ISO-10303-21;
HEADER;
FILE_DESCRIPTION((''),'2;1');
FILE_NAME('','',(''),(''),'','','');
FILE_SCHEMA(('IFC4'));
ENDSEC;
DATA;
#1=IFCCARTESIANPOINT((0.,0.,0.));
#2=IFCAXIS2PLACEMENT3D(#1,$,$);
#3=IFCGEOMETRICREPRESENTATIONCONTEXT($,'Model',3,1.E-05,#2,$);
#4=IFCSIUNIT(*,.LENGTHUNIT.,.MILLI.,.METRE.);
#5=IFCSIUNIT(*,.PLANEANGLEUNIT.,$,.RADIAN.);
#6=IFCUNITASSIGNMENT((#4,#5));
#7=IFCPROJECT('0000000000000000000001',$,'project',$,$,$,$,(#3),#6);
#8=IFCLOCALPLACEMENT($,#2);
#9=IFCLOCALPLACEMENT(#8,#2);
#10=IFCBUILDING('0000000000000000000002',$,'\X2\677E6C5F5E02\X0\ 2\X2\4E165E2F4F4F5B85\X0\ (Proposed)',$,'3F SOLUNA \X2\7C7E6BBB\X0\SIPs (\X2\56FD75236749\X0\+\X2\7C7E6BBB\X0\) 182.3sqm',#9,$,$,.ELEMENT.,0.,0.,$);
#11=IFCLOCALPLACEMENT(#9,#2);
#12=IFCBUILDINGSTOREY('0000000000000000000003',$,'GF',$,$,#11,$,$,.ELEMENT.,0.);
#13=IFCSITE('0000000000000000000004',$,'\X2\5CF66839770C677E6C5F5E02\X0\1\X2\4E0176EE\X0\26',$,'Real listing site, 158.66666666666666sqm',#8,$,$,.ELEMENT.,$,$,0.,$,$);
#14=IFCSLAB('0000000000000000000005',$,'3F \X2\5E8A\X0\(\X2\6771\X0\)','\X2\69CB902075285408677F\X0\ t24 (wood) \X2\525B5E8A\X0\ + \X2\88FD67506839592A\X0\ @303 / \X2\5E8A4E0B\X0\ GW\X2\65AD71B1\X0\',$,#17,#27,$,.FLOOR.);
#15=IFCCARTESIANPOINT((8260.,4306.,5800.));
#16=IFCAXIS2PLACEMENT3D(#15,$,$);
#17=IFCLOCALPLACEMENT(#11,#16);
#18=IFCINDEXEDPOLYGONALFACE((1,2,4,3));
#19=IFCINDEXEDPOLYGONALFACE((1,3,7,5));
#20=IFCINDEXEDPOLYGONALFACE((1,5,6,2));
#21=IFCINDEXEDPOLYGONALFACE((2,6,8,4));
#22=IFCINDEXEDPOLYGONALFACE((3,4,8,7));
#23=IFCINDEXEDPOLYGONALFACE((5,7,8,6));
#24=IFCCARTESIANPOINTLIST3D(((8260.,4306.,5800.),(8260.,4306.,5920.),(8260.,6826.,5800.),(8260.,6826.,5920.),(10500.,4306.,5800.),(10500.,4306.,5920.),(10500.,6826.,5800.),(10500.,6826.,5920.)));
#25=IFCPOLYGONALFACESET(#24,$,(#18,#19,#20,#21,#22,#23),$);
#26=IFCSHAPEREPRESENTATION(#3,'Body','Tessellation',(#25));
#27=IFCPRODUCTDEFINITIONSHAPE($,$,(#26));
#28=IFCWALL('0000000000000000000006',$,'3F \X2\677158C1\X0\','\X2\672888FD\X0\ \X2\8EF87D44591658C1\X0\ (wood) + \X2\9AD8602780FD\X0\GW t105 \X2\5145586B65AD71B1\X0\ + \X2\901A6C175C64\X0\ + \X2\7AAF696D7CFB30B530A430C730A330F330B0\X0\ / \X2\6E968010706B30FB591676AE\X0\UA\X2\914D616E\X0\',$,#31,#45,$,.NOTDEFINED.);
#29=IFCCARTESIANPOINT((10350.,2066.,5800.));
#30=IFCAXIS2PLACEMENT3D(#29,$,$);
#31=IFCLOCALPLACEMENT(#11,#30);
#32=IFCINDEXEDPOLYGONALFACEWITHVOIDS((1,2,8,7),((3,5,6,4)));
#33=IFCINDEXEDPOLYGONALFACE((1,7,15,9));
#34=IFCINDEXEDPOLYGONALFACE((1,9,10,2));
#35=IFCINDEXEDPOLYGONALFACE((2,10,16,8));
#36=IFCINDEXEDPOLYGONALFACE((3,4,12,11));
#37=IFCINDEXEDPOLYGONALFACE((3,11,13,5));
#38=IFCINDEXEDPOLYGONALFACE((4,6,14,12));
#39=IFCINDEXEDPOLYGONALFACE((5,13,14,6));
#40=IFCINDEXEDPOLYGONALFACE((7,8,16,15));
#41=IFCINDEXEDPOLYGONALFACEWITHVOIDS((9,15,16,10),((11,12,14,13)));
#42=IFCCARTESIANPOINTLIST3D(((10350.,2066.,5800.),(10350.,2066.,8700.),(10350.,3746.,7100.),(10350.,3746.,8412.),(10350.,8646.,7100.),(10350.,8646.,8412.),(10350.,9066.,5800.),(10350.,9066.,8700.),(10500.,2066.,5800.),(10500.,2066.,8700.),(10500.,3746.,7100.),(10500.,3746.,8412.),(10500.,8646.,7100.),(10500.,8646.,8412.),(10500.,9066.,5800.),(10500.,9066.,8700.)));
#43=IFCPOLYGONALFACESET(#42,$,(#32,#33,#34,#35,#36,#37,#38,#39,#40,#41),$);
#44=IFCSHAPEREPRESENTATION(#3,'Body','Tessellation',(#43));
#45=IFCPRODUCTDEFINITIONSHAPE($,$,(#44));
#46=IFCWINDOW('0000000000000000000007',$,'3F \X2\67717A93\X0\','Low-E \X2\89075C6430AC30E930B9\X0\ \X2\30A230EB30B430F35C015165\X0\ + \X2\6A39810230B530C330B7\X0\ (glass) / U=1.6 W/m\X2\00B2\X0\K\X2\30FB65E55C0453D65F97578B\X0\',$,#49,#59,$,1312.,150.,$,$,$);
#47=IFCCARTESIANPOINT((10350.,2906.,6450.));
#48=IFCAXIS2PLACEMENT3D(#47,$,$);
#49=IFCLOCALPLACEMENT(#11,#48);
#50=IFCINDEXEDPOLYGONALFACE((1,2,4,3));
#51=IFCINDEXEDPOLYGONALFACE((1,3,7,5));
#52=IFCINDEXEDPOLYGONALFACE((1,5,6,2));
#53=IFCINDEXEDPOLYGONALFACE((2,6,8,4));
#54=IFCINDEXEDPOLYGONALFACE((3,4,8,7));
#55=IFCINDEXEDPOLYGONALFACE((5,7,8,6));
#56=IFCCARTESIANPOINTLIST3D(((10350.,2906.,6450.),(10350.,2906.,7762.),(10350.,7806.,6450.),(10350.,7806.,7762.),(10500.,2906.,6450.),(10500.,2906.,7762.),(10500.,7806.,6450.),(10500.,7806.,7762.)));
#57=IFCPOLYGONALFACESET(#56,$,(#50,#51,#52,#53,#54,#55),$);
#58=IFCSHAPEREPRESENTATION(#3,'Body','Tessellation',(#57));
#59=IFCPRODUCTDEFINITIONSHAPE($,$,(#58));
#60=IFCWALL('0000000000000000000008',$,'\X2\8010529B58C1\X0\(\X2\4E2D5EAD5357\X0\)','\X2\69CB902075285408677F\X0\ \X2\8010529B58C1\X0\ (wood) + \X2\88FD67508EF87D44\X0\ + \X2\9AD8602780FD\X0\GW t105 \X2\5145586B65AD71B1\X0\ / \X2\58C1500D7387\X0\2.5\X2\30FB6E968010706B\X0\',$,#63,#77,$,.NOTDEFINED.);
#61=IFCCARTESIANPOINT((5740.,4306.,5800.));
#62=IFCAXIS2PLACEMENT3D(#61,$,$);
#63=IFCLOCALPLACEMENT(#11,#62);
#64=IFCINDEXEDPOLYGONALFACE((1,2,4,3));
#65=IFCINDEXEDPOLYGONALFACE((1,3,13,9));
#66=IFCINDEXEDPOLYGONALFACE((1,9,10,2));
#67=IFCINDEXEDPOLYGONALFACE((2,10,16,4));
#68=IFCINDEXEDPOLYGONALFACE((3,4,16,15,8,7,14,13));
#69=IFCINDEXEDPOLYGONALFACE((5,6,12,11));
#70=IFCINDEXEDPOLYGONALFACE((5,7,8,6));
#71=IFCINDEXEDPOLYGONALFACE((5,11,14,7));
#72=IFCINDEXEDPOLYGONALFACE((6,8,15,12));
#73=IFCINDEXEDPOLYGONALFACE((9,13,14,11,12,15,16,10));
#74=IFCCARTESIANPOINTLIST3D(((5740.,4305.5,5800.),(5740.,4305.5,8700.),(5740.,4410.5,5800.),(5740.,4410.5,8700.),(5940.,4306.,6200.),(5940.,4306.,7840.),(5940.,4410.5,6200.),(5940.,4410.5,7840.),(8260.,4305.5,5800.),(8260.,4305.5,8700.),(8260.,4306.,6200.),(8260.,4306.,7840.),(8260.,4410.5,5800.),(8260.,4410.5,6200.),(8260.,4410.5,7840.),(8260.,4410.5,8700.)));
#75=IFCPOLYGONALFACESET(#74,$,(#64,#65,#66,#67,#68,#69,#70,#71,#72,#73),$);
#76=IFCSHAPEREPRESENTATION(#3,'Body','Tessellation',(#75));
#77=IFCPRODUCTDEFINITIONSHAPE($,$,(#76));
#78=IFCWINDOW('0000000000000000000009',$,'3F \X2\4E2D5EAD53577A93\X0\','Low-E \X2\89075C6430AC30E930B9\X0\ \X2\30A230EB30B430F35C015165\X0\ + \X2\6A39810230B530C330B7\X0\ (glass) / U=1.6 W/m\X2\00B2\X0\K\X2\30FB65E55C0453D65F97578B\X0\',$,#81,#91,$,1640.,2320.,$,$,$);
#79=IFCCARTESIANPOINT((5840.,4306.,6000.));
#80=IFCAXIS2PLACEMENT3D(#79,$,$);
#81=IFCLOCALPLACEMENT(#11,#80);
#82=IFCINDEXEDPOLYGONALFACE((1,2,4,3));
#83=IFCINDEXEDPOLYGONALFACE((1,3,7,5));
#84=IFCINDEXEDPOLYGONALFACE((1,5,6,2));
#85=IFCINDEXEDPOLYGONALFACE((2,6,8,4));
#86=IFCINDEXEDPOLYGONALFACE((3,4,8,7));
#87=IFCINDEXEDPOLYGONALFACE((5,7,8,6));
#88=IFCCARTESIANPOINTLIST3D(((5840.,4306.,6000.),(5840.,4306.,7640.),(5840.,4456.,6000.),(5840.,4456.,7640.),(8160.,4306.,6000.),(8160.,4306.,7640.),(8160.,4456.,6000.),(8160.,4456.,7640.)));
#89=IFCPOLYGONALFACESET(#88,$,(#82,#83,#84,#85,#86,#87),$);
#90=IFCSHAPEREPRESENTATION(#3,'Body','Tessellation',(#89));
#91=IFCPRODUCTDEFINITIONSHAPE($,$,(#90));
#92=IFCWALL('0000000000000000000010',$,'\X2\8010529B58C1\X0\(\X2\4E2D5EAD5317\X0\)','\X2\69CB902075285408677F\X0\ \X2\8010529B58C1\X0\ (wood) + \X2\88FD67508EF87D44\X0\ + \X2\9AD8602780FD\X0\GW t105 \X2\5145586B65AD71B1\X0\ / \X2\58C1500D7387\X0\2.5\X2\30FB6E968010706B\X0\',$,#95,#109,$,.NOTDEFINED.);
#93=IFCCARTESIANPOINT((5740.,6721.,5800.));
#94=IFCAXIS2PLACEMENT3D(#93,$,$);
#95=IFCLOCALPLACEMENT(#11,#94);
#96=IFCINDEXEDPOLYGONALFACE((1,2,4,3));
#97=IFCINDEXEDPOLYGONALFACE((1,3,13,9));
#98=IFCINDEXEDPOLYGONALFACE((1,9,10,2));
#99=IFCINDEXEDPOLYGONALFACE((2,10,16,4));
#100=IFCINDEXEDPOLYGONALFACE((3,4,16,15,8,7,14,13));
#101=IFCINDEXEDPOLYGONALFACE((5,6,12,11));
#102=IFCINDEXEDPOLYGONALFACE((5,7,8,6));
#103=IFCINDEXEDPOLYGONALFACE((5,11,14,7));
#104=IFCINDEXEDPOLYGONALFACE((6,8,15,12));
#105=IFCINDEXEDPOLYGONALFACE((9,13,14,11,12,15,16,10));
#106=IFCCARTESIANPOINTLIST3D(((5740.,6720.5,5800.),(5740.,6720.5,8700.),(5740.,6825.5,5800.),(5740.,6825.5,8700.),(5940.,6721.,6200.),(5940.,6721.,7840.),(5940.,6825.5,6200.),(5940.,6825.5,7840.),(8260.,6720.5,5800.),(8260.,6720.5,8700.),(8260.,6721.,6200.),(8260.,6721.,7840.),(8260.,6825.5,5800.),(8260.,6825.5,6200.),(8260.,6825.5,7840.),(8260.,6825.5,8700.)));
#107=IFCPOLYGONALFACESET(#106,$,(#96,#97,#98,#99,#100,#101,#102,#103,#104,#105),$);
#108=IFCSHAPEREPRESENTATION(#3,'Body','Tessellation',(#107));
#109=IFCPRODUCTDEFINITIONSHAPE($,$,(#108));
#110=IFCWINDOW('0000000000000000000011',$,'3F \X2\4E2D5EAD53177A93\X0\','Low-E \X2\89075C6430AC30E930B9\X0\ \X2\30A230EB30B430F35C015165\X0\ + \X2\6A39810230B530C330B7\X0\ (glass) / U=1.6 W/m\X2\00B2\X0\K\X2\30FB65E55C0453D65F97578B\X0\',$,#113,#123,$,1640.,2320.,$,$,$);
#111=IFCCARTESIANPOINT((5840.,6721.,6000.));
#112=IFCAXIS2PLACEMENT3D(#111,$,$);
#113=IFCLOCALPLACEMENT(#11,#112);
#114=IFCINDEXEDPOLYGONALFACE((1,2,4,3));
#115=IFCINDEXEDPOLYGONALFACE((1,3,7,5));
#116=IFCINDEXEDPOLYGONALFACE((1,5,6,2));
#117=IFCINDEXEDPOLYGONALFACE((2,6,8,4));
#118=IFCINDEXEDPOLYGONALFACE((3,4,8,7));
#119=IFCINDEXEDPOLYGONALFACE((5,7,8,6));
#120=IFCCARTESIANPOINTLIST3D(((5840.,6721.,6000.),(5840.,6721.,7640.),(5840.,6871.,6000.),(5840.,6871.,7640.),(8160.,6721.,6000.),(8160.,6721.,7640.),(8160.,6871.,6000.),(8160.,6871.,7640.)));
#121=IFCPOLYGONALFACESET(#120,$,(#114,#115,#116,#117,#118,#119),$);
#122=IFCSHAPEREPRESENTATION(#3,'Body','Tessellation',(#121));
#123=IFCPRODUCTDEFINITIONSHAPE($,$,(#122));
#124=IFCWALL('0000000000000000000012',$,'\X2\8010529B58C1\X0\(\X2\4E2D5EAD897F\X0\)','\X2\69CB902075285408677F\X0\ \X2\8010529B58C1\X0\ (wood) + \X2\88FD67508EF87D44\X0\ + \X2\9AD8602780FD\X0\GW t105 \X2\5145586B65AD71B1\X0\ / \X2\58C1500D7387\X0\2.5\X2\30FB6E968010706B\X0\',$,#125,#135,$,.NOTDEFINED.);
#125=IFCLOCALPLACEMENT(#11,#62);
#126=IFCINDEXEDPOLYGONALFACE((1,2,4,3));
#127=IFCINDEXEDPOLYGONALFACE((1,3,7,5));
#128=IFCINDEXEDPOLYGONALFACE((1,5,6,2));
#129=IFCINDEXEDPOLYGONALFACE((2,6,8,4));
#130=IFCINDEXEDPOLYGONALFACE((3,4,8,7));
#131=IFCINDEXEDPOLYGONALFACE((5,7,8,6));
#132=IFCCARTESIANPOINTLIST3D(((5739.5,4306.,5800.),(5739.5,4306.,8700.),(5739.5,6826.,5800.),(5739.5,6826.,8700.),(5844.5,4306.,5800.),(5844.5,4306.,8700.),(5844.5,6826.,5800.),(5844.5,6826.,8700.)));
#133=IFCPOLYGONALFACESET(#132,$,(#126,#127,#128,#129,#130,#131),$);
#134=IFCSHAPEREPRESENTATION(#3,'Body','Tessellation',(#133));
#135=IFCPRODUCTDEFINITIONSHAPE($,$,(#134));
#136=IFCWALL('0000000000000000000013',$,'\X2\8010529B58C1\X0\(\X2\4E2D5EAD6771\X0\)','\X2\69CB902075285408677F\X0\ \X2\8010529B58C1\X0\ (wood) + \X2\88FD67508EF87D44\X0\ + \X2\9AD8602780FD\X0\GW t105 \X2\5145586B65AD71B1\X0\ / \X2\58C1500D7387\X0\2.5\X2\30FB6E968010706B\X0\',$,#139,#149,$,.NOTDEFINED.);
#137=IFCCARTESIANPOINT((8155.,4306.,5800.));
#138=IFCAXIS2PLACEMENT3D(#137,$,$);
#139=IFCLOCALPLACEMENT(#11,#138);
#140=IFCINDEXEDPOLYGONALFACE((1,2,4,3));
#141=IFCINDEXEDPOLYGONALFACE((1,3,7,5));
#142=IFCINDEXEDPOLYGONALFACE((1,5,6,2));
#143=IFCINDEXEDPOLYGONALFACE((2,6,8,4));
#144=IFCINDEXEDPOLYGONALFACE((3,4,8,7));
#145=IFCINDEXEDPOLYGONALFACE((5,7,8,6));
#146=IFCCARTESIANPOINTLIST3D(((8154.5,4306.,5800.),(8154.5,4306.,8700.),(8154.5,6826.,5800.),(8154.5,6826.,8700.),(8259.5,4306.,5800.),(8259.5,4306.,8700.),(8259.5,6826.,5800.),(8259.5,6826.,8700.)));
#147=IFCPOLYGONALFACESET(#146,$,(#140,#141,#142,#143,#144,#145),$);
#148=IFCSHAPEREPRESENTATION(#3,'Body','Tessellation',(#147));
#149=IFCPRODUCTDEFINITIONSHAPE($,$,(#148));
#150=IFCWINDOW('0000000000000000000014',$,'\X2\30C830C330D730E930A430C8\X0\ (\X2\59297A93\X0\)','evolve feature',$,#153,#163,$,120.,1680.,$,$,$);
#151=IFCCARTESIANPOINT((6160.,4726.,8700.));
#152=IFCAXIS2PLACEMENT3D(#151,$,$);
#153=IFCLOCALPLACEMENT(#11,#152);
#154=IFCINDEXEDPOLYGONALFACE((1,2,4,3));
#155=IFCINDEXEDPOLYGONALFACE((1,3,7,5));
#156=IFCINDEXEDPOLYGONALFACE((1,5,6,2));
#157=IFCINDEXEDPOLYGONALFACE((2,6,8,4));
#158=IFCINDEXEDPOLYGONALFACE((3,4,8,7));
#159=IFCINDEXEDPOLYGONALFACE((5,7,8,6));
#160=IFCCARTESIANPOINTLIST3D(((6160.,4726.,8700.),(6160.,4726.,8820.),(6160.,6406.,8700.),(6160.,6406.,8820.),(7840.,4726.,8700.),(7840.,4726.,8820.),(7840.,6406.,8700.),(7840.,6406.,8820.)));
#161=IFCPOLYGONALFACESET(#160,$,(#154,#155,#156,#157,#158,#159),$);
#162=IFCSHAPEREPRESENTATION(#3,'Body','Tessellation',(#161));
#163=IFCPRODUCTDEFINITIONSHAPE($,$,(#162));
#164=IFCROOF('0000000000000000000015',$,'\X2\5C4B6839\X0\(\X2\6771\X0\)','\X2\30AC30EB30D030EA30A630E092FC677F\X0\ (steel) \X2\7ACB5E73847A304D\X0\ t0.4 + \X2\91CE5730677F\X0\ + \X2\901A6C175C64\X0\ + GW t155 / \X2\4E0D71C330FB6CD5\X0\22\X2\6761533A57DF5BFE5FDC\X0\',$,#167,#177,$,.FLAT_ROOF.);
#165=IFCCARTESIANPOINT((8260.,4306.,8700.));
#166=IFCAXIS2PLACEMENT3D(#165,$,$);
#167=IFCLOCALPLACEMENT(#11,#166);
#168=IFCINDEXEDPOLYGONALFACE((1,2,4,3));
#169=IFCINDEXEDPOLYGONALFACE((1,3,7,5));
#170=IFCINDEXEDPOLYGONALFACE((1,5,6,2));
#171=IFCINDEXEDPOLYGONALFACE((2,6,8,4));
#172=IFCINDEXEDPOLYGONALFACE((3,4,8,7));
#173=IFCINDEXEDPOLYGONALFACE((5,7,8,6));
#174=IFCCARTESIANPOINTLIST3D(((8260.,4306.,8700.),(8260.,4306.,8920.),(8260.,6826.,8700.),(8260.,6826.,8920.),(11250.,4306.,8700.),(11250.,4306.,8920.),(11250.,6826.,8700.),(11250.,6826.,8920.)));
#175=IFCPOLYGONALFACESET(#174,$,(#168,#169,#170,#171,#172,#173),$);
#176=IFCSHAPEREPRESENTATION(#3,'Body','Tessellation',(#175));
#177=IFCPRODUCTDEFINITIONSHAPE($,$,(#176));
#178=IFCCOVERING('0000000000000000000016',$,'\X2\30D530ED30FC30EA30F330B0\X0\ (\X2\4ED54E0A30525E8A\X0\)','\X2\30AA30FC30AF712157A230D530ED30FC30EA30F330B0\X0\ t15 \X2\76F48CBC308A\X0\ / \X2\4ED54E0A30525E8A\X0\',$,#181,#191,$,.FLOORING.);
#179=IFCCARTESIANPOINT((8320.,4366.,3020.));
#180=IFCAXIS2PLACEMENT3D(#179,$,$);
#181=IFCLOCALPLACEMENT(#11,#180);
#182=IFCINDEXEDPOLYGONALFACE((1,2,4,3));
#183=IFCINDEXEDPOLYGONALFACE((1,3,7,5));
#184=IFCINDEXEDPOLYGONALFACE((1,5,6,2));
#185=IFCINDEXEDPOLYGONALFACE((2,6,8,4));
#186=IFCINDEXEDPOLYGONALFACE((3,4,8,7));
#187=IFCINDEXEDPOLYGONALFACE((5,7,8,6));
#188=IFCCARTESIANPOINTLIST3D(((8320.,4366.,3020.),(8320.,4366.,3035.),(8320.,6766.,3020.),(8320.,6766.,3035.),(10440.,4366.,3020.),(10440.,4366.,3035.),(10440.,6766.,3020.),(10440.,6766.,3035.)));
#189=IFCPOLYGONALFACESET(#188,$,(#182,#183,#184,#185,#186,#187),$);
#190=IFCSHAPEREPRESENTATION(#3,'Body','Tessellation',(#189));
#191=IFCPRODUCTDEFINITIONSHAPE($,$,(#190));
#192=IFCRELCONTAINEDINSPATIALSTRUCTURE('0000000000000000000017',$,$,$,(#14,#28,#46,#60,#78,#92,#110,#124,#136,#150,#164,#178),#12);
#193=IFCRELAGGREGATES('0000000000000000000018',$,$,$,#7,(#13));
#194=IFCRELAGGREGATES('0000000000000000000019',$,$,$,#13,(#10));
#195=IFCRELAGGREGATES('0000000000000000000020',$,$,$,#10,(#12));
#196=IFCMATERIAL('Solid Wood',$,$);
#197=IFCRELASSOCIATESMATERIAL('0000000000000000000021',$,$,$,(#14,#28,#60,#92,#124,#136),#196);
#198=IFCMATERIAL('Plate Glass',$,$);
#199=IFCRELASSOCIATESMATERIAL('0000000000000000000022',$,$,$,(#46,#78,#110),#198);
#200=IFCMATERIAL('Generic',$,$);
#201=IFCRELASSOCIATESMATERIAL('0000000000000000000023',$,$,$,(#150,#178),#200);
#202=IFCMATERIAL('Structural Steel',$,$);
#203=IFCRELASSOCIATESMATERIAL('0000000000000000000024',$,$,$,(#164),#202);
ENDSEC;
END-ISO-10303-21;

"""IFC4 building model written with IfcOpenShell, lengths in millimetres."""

from ifc_helpers import new_model, si_unit, frame, frame_2d, origin, place, context, project, spatial, rectangle, extrude, material, element, fill, save


model = new_model("IFC4")

# Units and contexts
model_context = context("Model", 3, precision=1e-05, world=origin())
ifc_project = project(units=[si_unit("LENGTHUNIT", "METRE", prefix="MILLI"), si_unit("PLANEANGLEUNIT", "RADIAN")], contexts=[model_context])

# Site, building, storey
site_placement = place(None, origin())
site = spatial("IfcSite", under=ifc_project, at=site_placement, Name="島根県松江市1丁目26", ObjectType="Real listing site, 158.66666666666666sqm", CompositionType="ELEMENT", RefElevation=0.0)
building_placement = place(site_placement, origin())
building = spatial("IfcBuilding", under=site, at=building_placement, Name="松江市 2世帯住宅 (Proposed)", ObjectType="3F SOLUNA 籾殻SIPs (国産杉+籾殻) 182.3sqm", CompositionType="ELEMENT", ElevationOfRefHeight=0.0, ElevationOfTerrain=0.0)
storey_placement = place(building_placement, origin())
storey = spatial("IfcBuildingStorey", under=building, at=storey_placement, Name="GF", CompositionType="ELEMENT", Elevation=0.0)

# Slab
ifc_material_1 = material(Name="Solid Wood")
slab_placement = place(storey_placement, frame((8260.0, 4306.0, 5800.0)))
element("IfcSlab", 1, at=slab_placement, inside=storey, material=ifc_material_1, Name="3F 床(東)", Description="構造用合板 t24 (wood) 剛床 + 製材根太 @303 / 床下 GW断熱", PredefinedType="FLOOR", context=model_context, shape_type="SweptSolid", body=[
    extrude(rectangle(XDim=2240.0, YDim=2520.0, at=frame_2d((1120.0, 1260.0))), frame((8260.0, 4306.0, 5800.0)), (0.0, 0.0, 1.0), 120.0),
])

# Walls, openings, windows
wall_1_placement = place(storey_placement, frame((10350.0, 2066.0, 5800.0)))
wall_1 = element("IfcWall", 2, at=wall_1_placement, inside=storey, material=ifc_material_1, Name="3F 東壁", Description="木製 軸組外壁 (wood) + 高性能GW t105 充填断熱 + 通気層 + 窯業系サイディング / 準耐火・外皮UA配慮", PredefinedType="NOTDEFINED", context=model_context, shape_type="SweptSolid", body=[
    extrude(rectangle(XDim=150.0, YDim=7000.0, at=frame_2d((75.0, 3500.0))), frame((10350.0, 2066.0, 5800.0)), (0.0, 0.0, 1.0), 2900.0),
])
opening_1_placement = place(storey_placement, frame((10350.0, 2906.0, 6450.0)))
opening_1 = element("IfcOpeningElement", 3, at=opening_1_placement, cuts=wall_1, PredefinedType="NOTDEFINED", context=model_context, shape_type="SweptSolid", body=[
    extrude(rectangle(XDim=150.0, YDim=4900.0, at=frame_2d((75.0, 2450.0))), frame((10350.0, 2906.0, 6450.0)), (0.0, 0.0, 1.0), 1312.0),
])
ifc_material_2 = material(Name="Plate Glass")
window_1_placement = place(storey_placement, frame((10350.0, 2906.0, 6450.0)))
window_1 = element("IfcWindow", 4, at=window_1_placement, inside=storey, material=ifc_material_2, Name="3F 東窓", Description="Low-E 複層ガラス アルゴン封入 + 樹脂サッシ (glass) / U=1.6 W/m²K・日射取得型", OverallHeight=1312.0, OverallWidth=150.0, context=model_context, shape_type="SweptSolid", body=[
    extrude(rectangle(XDim=150.0, YDim=4900.0, at=frame_2d((75.0, 2450.0))), frame((10350.0, 2906.0, 6450.0)), (0.0, 0.0, 1.0), 1312.0),
])
fill(opening_1, window_1)
wall_2_placement = place(storey_placement, frame((5740.0, 4306.0, 5800.0)))
wall_2 = element("IfcWall", 5, at=wall_2_placement, inside=storey, material=ifc_material_1, Name="耐力壁(中庭南)", Description="構造用合板 耐力壁 (wood) + 製材軸組 + 高性能GW t105 充填断熱 / 壁倍率2.5・準耐火", PredefinedType="NOTDEFINED", context=model_context, shape_type="SweptSolid", body=[
    extrude(rectangle(XDim=2520.0, YDim=105.0, at=frame_2d((1260.0, 52.0))), frame((5740.0, 4306.0, 5800.0)), (0.0, 0.0, 1.0), 2900.0),
])
opening_2_placement = place(storey_placement, frame((5840.0, 4306.0, 6000.0)))
opening_2 = element("IfcOpeningElement", 6, at=opening_2_placement, cuts=wall_2, PredefinedType="NOTDEFINED", context=model_context, shape_type="SweptSolid", body=[
    extrude(rectangle(XDim=2320.0, YDim=150.0, at=frame_2d((1160.0, 75.0))), frame((5840.0, 4306.0, 6000.0)), (0.0, 0.0, 1.0), 1640.0),
])
window_2_placement = place(storey_placement, frame((5840.0, 4306.0, 6000.0)))
window_2 = element("IfcWindow", 7, at=window_2_placement, inside=storey, material=ifc_material_2, Name="3F 中庭南窓", Description="Low-E 複層ガラス アルゴン封入 + 樹脂サッシ (glass) / U=1.6 W/m²K・日射取得型", OverallHeight=1640.0, OverallWidth=2320.0, context=model_context, shape_type="SweptSolid", body=[
    extrude(rectangle(XDim=2320.0, YDim=150.0, at=frame_2d((1160.0, 75.0))), frame((5840.0, 4306.0, 6000.0)), (0.0, 0.0, 1.0), 1640.0),
])
fill(opening_2, window_2)
wall_3_placement = place(storey_placement, frame((5740.0, 6721.0, 5800.0)))
wall_3 = element("IfcWall", 8, at=wall_3_placement, inside=storey, material=ifc_material_1, Name="耐力壁(中庭北)", Description="構造用合板 耐力壁 (wood) + 製材軸組 + 高性能GW t105 充填断熱 / 壁倍率2.5・準耐火", PredefinedType="NOTDEFINED", context=model_context, shape_type="SweptSolid", body=[
    extrude(rectangle(XDim=2520.0, YDim=105.0, at=frame_2d((1260.0, 52.0))), frame((5740.0, 6721.0, 5800.0)), (0.0, 0.0, 1.0), 2900.0),
])
opening_3_placement = place(storey_placement, frame((5840.0, 6721.0, 6000.0)))
opening_3 = element("IfcOpeningElement", 9, at=opening_3_placement, cuts=wall_3, PredefinedType="NOTDEFINED", context=model_context, shape_type="SweptSolid", body=[
    extrude(rectangle(XDim=2320.0, YDim=150.0, at=frame_2d((1160.0, 75.0))), frame((5840.0, 6721.0, 6000.0)), (0.0, 0.0, 1.0), 1640.0),
])
window_3_placement = place(storey_placement, frame((5840.0, 6721.0, 6000.0)))
window_3 = element("IfcWindow", 10, at=window_3_placement, inside=storey, material=ifc_material_2, Name="3F 中庭北窓", Description="Low-E 複層ガラス アルゴン封入 + 樹脂サッシ (glass) / U=1.6 W/m²K・日射取得型", OverallHeight=1640.0, OverallWidth=2320.0, context=model_context, shape_type="SweptSolid", body=[
    extrude(rectangle(XDim=2320.0, YDim=150.0, at=frame_2d((1160.0, 75.0))), frame((5840.0, 6721.0, 6000.0)), (0.0, 0.0, 1.0), 1640.0),
])
fill(opening_3, window_3)

# Walls
wall_4_placement = place(storey_placement, frame((5740.0, 4306.0, 5800.0)))
element("IfcWall", 11, at=wall_4_placement, inside=storey, material=ifc_material_1, Name="耐力壁(中庭西)", Description="構造用合板 耐力壁 (wood) + 製材軸組 + 高性能GW t105 充填断熱 / 壁倍率2.5・準耐火", PredefinedType="NOTDEFINED", context=model_context, shape_type="SweptSolid", body=[
    extrude(rectangle(XDim=105.0, YDim=2520.0, at=frame_2d((52.0, 1260.0))), frame((5740.0, 4306.0, 5800.0)), (0.0, 0.0, 1.0), 2900.0),
])
wall_5_placement = place(storey_placement, frame((8155.0, 4306.0, 5800.0)))
element("IfcWall", 12, at=wall_5_placement, inside=storey, material=ifc_material_1, Name="耐力壁(中庭東)", Description="構造用合板 耐力壁 (wood) + 製材軸組 + 高性能GW t105 充填断熱 / 壁倍率2.5・準耐火", PredefinedType="NOTDEFINED", context=model_context, shape_type="SweptSolid", body=[
    extrude(rectangle(XDim=105.0, YDim=2520.0, at=frame_2d((52.0, 1260.0))), frame((8155.0, 4306.0, 5800.0)), (0.0, 0.0, 1.0), 2900.0),
])

# Window
ifc_material_3 = material(Name="Generic")
window_4_placement = place(storey_placement, frame((6160.0, 4726.0, 8700.0)))
element("IfcWindow", 13, at=window_4_placement, inside=storey, material=ifc_material_3, Name="トップライト (天窓)", Description="evolve feature", OverallHeight=120.0, OverallWidth=1680.0, context=model_context, shape_type="SweptSolid", body=[
    extrude(rectangle(XDim=1680.0, YDim=1680.0, at=frame_2d((840.0, 840.0))), frame((6160.0, 4726.0, 8700.0)), (0.0, 0.0, 1.0), 120.0),
])

# Roof
ifc_material_4 = material(Name="Structural Steel")
for number, where, name in (
    (14, (8260.0, 4306.0, 8700.0), "屋根(東)"),
):
    element("IfcRoof", number, at=place(storey_placement, frame(where)), inside=storey, material=ifc_material_4, Name=name, Description="ガルバリウム鋼板 (steel) 立平葺き t0.4 + 野地板 + 通気層 + GW t155 / 不燃・法22条区域対応", PredefinedType="FLAT_ROOF", context=model_context, shape_type="SweptSolid", body=[
        extrude(rectangle(XDim=2990.0, YDim=2520.0, at=frame_2d((1495.0, 1260.0))), frame((8260.0, 4306.0, 8700.0)), (0.0, 0.0, 1.0), 220.0),
    ])

# Covering
covering_1_placement = place(storey_placement, frame((8320.0, 4366.0, 3020.0)))
element("IfcCovering", 15, at=covering_1_placement, inside=storey, material=ifc_material_3, Name="フローリング (仕上げ床)", Description="オーク無垢フローリング t15 直貼り / 仕上げ床", PredefinedType="FLOORING", context=model_context, shape_type="SweptSolid", body=[
    extrude(rectangle(XDim=2120.0, YDim=2400.0, at=frame_2d((1060.0, 1200.0))), frame((8320.0, 4366.0, 3020.0)), (0.0, 0.0, 1.0), 15.0),
])

save(model, "model.ifc")
